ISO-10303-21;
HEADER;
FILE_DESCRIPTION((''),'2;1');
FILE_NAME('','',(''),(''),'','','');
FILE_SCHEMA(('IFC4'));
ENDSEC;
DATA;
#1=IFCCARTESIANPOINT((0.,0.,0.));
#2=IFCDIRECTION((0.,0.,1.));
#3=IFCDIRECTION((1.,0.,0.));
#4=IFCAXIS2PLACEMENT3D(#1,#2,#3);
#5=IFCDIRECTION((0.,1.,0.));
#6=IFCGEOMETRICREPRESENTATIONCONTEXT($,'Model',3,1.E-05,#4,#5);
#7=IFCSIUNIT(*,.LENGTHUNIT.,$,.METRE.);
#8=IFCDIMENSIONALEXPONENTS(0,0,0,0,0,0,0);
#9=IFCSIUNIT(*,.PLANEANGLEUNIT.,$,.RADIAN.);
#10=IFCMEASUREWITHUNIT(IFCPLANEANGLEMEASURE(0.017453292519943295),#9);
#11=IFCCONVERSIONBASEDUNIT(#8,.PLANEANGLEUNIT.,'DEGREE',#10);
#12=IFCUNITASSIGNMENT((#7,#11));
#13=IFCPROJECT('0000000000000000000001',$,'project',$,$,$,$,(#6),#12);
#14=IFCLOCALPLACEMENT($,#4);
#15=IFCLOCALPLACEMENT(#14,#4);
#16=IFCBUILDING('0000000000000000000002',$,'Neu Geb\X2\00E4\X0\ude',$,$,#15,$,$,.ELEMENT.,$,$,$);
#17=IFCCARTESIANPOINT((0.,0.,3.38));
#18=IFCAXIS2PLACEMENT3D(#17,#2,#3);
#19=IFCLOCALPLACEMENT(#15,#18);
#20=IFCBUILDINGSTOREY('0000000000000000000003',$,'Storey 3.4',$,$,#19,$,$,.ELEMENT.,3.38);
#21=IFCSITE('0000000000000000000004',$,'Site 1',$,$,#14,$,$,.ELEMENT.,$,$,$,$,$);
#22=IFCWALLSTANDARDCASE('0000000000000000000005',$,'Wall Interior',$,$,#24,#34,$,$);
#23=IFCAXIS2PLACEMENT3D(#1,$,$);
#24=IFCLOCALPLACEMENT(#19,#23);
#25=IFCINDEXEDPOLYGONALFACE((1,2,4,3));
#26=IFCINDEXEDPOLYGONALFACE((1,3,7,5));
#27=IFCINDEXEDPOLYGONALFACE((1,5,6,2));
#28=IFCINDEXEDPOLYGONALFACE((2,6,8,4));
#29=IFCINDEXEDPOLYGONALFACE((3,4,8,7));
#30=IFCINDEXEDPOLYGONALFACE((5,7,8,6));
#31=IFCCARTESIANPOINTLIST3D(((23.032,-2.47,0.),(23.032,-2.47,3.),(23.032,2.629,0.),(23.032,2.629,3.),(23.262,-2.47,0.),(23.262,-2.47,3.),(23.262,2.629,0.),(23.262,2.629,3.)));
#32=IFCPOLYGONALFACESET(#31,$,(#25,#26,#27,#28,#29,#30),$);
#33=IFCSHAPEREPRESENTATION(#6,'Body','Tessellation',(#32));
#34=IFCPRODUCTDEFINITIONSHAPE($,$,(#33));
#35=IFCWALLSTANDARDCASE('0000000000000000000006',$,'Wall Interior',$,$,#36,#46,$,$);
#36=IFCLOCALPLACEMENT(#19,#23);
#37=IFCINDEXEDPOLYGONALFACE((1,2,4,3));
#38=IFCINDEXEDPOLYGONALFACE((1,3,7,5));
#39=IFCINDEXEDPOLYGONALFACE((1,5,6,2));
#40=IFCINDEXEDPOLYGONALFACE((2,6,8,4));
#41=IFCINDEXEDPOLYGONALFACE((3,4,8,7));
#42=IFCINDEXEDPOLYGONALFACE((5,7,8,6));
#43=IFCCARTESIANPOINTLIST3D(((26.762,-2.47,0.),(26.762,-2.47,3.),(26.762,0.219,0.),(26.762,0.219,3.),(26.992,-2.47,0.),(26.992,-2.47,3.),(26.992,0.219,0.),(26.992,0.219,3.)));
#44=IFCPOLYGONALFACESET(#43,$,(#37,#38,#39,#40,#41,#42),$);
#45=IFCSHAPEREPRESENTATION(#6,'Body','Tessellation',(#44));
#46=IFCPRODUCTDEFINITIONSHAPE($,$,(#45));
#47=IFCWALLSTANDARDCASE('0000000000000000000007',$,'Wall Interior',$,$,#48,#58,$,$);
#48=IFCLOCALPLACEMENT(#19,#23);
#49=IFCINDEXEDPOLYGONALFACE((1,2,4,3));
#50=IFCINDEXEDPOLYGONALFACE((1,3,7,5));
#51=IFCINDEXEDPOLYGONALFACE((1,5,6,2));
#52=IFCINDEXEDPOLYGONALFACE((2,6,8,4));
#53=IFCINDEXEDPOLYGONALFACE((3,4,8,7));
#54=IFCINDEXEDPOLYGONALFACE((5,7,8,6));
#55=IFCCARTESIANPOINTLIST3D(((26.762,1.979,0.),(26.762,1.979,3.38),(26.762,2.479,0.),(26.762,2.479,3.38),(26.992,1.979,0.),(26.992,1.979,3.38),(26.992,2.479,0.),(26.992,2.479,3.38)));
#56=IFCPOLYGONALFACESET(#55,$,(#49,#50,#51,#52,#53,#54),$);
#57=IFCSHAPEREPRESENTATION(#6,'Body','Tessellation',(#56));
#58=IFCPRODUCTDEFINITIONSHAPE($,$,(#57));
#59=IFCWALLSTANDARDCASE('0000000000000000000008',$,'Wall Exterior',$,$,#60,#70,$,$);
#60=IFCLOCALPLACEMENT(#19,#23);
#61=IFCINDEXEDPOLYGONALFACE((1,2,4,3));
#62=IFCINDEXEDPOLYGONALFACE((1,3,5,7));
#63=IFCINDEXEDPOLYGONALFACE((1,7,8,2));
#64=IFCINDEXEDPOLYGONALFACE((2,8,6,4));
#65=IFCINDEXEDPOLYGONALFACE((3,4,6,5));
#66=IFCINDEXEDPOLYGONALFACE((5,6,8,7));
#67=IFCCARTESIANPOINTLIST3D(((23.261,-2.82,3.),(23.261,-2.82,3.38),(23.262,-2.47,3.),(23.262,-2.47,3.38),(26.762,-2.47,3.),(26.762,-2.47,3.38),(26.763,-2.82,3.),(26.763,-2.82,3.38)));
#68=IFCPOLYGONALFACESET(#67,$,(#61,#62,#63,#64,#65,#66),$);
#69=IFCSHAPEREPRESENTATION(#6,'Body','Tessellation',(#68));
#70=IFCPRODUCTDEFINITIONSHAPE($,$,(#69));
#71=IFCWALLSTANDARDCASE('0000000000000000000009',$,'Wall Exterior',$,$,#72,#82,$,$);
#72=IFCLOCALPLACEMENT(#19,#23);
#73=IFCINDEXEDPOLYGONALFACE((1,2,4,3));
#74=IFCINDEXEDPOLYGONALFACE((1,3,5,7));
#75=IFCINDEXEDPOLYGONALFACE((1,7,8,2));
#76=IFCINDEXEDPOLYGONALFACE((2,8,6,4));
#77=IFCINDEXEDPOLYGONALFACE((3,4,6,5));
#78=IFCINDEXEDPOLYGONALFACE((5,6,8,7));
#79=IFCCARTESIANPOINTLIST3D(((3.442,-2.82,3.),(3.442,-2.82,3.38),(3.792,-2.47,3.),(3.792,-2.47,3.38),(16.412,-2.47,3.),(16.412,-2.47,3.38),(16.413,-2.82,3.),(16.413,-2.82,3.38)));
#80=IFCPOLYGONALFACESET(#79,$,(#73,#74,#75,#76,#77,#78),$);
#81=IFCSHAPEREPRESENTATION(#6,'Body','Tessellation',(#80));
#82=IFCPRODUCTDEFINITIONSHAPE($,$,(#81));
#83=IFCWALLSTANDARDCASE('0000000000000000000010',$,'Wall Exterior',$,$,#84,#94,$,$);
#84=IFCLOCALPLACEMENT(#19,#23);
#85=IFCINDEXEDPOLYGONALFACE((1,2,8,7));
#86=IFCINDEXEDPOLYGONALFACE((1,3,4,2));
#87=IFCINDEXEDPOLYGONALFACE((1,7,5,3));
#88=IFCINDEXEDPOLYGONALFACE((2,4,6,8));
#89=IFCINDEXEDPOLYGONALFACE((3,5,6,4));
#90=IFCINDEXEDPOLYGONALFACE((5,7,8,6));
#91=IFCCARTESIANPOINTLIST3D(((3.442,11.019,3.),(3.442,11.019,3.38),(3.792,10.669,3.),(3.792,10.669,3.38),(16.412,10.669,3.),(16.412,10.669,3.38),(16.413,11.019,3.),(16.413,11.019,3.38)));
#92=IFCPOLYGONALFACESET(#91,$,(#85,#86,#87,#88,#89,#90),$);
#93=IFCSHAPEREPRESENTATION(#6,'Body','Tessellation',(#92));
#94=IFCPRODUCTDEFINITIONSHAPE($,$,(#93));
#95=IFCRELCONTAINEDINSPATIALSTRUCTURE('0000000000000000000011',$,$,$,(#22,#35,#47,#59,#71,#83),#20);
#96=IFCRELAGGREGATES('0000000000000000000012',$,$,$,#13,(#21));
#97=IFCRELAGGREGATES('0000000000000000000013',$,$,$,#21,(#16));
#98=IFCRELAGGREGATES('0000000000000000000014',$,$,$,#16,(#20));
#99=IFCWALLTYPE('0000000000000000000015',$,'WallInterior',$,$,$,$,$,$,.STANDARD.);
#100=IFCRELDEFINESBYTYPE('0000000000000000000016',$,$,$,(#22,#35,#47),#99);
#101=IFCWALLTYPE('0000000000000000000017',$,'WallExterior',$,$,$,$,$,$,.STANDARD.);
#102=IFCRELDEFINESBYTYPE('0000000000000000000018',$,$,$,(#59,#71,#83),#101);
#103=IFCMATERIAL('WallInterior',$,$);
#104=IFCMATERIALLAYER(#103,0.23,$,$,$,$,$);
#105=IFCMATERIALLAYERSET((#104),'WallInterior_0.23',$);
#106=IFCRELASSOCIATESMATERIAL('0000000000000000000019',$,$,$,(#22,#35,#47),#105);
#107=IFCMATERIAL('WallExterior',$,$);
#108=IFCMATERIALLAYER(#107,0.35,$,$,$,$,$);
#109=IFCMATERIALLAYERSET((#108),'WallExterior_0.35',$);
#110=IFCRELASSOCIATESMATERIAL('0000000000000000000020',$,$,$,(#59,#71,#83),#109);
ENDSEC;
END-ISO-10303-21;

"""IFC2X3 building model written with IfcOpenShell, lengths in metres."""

from ifc_helpers import new_model, entity, si_unit, converted_unit, direction, frame, origin_with_axes, place, context, project, spatial, polyline, outline, extrude, material, layer, layer_set, layer_usage, type_object, element, save


model = new_model("IFC2X3")

# Units and contexts
model_context = context("Model", 3, precision=1e-05, world=origin_with_axes(), true_north=direction((0.0, 1.0, 0.0)))
ifc_project = project(units=[si_unit("LENGTHUNIT", "METRE"), converted_unit("PLANEANGLEUNIT", "DEGREE", entity("IfcPlaneAngleMeasure", 0.017453292519943295), si_unit("PLANEANGLEUNIT", "RADIAN"), dimensions=[0, 0, 0, 0, 0, 0, 0])], contexts=[model_context])

# Site, building, storey
site_placement = place(None, origin_with_axes())
site = spatial("IfcSite", under=ifc_project, at=site_placement, Name="Site 1", CompositionType="ELEMENT")
building_placement = place(site_placement, origin_with_axes())
building = spatial("IfcBuilding", under=site, at=building_placement, Name="Neu Gebäude", CompositionType="ELEMENT")
storey_placement = place(building_placement, frame((0.0, 0.0, 3.38), z_axis=(0.0, 0.0, 1.0), x_axis=(1.0, 0.0, 0.0)))
storey = spatial("IfcBuildingStorey", under=building, at=storey_placement, Name="Storey 3.4", CompositionType="ELEMENT", Elevation=3.38)

# Walls
ifc_material_1 = material(Name="WallInterior")
ifc_layer_1 = layer(ifc_material_1, 0.23)
ifc_layer_set_1 = layer_set([ifc_layer_1], Name="WallInterior_0.23")
ifc_layer_usage_1 = layer_usage(ifc_layer_set_1, "AXIS2", "POSITIVE", -0.115)
wall_type_1 = type_object("IfcWallType", Name="WallInterior", PredefinedType="STANDARD")
wall_1_placement = place(storey_placement, frame((23.147, -2.47, 0.0), z_axis=(0.0, 0.0, 1.0), x_axis=(0.0, 1.0, 0.0)))
element("IfcWallStandardCase", 1, at=wall_1_placement, inside=storey, type_object=wall_type_1, material=ifc_layer_usage_1, Name="Wall Interior", context=model_context, shape_type="SweptSolid", body=[
    extrude(outline(polyline([(5.099, -0.115), (5.099, 0.115), (0.0, 0.115), (0.0, -0.115), (5.099, -0.115)])), origin_with_axes(), (0.0, 0.0, 1.0), 3.0),
])
wall_2_placement = place(storey_placement, frame((26.877, -2.47, 0.0), z_axis=(0.0, 0.0, 1.0), x_axis=(0.0, 1.0, 0.0)))
element("IfcWallStandardCase", 2, at=wall_2_placement, inside=storey, type_object=wall_type_1, material=ifc_layer_usage_1, Name="Wall Interior", context=model_context, shape_type="SweptSolid", body=[
    extrude(outline(polyline([(2.689, -0.115), (2.689, 0.115), (0.0, 0.115), (0.0, -0.115), (2.689, -0.115)])), origin_with_axes(), (0.0, 0.0, 1.0), 3.0),
])

# Wall
wall_3_placement = place(storey_placement, frame((26.877, 1.979, 0.0), z_axis=(0.0, 0.0, 1.0), x_axis=(0.0, 1.0, 0.0)))
element("IfcWallStandardCase", 3, at=wall_3_placement, inside=storey, type_object=wall_type_1, material=ifc_layer_usage_1, Name="Wall Interior", context=model_context, shape_type="SweptSolid", body=[
    extrude(outline(polyline([(0.5, -0.115), (0.5, 0.115), (0.0, 0.115), (0.0, -0.115), (0.5, -0.115)])), origin_with_axes(), (0.0, 0.0, 1.0), 3.38),
])

# Shared definitions
ifc_material_2 = material(Name="WallExterior")
ifc_layer_2 = layer(ifc_material_2, 0.35)
ifc_layer_set_2 = layer_set([ifc_layer_2], Name="WallExterior_0.35")
ifc_layer_usage_2 = layer_usage(ifc_layer_set_2, "AXIS2", "POSITIVE", -0.175)
wall_type_2 = type_object("IfcWallType", Name="WallExterior", PredefinedType="STANDARD")

# Walls
wall_4_placement = place(storey_placement, frame((26.763, -2.645, 3.0), z_axis=(0.0, 0.0, 1.0), x_axis=(-1.0, 0.0, 0.0)))
element("IfcWallStandardCase", 4, at=wall_4_placement, inside=storey, type_object=wall_type_2, material=ifc_layer_usage_2, Name="Wall Exterior", context=model_context, shape_type="SweptSolid", body=[
    extrude(outline(polyline([(0.001, -0.175), (3.501, -0.175), (3.502, 0.175), (0.0, 0.175), (0.001, -0.175)])), origin_with_axes(), (0.0, 0.0, 1.0), 0.38),
])
wall_5_placement = place(storey_placement, frame((16.413, -2.645, 3.0), z_axis=(0.0, 0.0, 1.0), x_axis=(-1.0, 0.0, 0.0)))
element("IfcWallStandardCase", 5, at=wall_5_placement, inside=storey, type_object=wall_type_2, material=ifc_layer_usage_2, Name="Wall Exterior", context=model_context, shape_type="SweptSolid", body=[
    extrude(outline(polyline([(0.001, -0.175), (12.621, -0.175), (12.971, 0.175), (0.0, 0.175), (0.001, -0.175)])), origin_with_axes(), (0.0, 0.0, 1.0), 0.38),
])
wall_6_placement = place(storey_placement, frame((16.413, 10.844, 3.0), z_axis=(0.0, 0.0, 1.0), x_axis=(-1.0, 0.0, 0.0)))
element("IfcWallStandardCase", 6, at=wall_6_placement, inside=storey, type_object=wall_type_2, material=ifc_layer_usage_2, Name="Wall Exterior", context=model_context, shape_type="SweptSolid", body=[
    extrude(outline(polyline([(0.0, -0.175), (12.971, -0.175), (12.621, 0.175), (0.001, 0.175), (0.0, -0.175)])), origin_with_axes(), (0.0, 0.0, 1.0), 0.38),
])

save(model, "model.ifc")
